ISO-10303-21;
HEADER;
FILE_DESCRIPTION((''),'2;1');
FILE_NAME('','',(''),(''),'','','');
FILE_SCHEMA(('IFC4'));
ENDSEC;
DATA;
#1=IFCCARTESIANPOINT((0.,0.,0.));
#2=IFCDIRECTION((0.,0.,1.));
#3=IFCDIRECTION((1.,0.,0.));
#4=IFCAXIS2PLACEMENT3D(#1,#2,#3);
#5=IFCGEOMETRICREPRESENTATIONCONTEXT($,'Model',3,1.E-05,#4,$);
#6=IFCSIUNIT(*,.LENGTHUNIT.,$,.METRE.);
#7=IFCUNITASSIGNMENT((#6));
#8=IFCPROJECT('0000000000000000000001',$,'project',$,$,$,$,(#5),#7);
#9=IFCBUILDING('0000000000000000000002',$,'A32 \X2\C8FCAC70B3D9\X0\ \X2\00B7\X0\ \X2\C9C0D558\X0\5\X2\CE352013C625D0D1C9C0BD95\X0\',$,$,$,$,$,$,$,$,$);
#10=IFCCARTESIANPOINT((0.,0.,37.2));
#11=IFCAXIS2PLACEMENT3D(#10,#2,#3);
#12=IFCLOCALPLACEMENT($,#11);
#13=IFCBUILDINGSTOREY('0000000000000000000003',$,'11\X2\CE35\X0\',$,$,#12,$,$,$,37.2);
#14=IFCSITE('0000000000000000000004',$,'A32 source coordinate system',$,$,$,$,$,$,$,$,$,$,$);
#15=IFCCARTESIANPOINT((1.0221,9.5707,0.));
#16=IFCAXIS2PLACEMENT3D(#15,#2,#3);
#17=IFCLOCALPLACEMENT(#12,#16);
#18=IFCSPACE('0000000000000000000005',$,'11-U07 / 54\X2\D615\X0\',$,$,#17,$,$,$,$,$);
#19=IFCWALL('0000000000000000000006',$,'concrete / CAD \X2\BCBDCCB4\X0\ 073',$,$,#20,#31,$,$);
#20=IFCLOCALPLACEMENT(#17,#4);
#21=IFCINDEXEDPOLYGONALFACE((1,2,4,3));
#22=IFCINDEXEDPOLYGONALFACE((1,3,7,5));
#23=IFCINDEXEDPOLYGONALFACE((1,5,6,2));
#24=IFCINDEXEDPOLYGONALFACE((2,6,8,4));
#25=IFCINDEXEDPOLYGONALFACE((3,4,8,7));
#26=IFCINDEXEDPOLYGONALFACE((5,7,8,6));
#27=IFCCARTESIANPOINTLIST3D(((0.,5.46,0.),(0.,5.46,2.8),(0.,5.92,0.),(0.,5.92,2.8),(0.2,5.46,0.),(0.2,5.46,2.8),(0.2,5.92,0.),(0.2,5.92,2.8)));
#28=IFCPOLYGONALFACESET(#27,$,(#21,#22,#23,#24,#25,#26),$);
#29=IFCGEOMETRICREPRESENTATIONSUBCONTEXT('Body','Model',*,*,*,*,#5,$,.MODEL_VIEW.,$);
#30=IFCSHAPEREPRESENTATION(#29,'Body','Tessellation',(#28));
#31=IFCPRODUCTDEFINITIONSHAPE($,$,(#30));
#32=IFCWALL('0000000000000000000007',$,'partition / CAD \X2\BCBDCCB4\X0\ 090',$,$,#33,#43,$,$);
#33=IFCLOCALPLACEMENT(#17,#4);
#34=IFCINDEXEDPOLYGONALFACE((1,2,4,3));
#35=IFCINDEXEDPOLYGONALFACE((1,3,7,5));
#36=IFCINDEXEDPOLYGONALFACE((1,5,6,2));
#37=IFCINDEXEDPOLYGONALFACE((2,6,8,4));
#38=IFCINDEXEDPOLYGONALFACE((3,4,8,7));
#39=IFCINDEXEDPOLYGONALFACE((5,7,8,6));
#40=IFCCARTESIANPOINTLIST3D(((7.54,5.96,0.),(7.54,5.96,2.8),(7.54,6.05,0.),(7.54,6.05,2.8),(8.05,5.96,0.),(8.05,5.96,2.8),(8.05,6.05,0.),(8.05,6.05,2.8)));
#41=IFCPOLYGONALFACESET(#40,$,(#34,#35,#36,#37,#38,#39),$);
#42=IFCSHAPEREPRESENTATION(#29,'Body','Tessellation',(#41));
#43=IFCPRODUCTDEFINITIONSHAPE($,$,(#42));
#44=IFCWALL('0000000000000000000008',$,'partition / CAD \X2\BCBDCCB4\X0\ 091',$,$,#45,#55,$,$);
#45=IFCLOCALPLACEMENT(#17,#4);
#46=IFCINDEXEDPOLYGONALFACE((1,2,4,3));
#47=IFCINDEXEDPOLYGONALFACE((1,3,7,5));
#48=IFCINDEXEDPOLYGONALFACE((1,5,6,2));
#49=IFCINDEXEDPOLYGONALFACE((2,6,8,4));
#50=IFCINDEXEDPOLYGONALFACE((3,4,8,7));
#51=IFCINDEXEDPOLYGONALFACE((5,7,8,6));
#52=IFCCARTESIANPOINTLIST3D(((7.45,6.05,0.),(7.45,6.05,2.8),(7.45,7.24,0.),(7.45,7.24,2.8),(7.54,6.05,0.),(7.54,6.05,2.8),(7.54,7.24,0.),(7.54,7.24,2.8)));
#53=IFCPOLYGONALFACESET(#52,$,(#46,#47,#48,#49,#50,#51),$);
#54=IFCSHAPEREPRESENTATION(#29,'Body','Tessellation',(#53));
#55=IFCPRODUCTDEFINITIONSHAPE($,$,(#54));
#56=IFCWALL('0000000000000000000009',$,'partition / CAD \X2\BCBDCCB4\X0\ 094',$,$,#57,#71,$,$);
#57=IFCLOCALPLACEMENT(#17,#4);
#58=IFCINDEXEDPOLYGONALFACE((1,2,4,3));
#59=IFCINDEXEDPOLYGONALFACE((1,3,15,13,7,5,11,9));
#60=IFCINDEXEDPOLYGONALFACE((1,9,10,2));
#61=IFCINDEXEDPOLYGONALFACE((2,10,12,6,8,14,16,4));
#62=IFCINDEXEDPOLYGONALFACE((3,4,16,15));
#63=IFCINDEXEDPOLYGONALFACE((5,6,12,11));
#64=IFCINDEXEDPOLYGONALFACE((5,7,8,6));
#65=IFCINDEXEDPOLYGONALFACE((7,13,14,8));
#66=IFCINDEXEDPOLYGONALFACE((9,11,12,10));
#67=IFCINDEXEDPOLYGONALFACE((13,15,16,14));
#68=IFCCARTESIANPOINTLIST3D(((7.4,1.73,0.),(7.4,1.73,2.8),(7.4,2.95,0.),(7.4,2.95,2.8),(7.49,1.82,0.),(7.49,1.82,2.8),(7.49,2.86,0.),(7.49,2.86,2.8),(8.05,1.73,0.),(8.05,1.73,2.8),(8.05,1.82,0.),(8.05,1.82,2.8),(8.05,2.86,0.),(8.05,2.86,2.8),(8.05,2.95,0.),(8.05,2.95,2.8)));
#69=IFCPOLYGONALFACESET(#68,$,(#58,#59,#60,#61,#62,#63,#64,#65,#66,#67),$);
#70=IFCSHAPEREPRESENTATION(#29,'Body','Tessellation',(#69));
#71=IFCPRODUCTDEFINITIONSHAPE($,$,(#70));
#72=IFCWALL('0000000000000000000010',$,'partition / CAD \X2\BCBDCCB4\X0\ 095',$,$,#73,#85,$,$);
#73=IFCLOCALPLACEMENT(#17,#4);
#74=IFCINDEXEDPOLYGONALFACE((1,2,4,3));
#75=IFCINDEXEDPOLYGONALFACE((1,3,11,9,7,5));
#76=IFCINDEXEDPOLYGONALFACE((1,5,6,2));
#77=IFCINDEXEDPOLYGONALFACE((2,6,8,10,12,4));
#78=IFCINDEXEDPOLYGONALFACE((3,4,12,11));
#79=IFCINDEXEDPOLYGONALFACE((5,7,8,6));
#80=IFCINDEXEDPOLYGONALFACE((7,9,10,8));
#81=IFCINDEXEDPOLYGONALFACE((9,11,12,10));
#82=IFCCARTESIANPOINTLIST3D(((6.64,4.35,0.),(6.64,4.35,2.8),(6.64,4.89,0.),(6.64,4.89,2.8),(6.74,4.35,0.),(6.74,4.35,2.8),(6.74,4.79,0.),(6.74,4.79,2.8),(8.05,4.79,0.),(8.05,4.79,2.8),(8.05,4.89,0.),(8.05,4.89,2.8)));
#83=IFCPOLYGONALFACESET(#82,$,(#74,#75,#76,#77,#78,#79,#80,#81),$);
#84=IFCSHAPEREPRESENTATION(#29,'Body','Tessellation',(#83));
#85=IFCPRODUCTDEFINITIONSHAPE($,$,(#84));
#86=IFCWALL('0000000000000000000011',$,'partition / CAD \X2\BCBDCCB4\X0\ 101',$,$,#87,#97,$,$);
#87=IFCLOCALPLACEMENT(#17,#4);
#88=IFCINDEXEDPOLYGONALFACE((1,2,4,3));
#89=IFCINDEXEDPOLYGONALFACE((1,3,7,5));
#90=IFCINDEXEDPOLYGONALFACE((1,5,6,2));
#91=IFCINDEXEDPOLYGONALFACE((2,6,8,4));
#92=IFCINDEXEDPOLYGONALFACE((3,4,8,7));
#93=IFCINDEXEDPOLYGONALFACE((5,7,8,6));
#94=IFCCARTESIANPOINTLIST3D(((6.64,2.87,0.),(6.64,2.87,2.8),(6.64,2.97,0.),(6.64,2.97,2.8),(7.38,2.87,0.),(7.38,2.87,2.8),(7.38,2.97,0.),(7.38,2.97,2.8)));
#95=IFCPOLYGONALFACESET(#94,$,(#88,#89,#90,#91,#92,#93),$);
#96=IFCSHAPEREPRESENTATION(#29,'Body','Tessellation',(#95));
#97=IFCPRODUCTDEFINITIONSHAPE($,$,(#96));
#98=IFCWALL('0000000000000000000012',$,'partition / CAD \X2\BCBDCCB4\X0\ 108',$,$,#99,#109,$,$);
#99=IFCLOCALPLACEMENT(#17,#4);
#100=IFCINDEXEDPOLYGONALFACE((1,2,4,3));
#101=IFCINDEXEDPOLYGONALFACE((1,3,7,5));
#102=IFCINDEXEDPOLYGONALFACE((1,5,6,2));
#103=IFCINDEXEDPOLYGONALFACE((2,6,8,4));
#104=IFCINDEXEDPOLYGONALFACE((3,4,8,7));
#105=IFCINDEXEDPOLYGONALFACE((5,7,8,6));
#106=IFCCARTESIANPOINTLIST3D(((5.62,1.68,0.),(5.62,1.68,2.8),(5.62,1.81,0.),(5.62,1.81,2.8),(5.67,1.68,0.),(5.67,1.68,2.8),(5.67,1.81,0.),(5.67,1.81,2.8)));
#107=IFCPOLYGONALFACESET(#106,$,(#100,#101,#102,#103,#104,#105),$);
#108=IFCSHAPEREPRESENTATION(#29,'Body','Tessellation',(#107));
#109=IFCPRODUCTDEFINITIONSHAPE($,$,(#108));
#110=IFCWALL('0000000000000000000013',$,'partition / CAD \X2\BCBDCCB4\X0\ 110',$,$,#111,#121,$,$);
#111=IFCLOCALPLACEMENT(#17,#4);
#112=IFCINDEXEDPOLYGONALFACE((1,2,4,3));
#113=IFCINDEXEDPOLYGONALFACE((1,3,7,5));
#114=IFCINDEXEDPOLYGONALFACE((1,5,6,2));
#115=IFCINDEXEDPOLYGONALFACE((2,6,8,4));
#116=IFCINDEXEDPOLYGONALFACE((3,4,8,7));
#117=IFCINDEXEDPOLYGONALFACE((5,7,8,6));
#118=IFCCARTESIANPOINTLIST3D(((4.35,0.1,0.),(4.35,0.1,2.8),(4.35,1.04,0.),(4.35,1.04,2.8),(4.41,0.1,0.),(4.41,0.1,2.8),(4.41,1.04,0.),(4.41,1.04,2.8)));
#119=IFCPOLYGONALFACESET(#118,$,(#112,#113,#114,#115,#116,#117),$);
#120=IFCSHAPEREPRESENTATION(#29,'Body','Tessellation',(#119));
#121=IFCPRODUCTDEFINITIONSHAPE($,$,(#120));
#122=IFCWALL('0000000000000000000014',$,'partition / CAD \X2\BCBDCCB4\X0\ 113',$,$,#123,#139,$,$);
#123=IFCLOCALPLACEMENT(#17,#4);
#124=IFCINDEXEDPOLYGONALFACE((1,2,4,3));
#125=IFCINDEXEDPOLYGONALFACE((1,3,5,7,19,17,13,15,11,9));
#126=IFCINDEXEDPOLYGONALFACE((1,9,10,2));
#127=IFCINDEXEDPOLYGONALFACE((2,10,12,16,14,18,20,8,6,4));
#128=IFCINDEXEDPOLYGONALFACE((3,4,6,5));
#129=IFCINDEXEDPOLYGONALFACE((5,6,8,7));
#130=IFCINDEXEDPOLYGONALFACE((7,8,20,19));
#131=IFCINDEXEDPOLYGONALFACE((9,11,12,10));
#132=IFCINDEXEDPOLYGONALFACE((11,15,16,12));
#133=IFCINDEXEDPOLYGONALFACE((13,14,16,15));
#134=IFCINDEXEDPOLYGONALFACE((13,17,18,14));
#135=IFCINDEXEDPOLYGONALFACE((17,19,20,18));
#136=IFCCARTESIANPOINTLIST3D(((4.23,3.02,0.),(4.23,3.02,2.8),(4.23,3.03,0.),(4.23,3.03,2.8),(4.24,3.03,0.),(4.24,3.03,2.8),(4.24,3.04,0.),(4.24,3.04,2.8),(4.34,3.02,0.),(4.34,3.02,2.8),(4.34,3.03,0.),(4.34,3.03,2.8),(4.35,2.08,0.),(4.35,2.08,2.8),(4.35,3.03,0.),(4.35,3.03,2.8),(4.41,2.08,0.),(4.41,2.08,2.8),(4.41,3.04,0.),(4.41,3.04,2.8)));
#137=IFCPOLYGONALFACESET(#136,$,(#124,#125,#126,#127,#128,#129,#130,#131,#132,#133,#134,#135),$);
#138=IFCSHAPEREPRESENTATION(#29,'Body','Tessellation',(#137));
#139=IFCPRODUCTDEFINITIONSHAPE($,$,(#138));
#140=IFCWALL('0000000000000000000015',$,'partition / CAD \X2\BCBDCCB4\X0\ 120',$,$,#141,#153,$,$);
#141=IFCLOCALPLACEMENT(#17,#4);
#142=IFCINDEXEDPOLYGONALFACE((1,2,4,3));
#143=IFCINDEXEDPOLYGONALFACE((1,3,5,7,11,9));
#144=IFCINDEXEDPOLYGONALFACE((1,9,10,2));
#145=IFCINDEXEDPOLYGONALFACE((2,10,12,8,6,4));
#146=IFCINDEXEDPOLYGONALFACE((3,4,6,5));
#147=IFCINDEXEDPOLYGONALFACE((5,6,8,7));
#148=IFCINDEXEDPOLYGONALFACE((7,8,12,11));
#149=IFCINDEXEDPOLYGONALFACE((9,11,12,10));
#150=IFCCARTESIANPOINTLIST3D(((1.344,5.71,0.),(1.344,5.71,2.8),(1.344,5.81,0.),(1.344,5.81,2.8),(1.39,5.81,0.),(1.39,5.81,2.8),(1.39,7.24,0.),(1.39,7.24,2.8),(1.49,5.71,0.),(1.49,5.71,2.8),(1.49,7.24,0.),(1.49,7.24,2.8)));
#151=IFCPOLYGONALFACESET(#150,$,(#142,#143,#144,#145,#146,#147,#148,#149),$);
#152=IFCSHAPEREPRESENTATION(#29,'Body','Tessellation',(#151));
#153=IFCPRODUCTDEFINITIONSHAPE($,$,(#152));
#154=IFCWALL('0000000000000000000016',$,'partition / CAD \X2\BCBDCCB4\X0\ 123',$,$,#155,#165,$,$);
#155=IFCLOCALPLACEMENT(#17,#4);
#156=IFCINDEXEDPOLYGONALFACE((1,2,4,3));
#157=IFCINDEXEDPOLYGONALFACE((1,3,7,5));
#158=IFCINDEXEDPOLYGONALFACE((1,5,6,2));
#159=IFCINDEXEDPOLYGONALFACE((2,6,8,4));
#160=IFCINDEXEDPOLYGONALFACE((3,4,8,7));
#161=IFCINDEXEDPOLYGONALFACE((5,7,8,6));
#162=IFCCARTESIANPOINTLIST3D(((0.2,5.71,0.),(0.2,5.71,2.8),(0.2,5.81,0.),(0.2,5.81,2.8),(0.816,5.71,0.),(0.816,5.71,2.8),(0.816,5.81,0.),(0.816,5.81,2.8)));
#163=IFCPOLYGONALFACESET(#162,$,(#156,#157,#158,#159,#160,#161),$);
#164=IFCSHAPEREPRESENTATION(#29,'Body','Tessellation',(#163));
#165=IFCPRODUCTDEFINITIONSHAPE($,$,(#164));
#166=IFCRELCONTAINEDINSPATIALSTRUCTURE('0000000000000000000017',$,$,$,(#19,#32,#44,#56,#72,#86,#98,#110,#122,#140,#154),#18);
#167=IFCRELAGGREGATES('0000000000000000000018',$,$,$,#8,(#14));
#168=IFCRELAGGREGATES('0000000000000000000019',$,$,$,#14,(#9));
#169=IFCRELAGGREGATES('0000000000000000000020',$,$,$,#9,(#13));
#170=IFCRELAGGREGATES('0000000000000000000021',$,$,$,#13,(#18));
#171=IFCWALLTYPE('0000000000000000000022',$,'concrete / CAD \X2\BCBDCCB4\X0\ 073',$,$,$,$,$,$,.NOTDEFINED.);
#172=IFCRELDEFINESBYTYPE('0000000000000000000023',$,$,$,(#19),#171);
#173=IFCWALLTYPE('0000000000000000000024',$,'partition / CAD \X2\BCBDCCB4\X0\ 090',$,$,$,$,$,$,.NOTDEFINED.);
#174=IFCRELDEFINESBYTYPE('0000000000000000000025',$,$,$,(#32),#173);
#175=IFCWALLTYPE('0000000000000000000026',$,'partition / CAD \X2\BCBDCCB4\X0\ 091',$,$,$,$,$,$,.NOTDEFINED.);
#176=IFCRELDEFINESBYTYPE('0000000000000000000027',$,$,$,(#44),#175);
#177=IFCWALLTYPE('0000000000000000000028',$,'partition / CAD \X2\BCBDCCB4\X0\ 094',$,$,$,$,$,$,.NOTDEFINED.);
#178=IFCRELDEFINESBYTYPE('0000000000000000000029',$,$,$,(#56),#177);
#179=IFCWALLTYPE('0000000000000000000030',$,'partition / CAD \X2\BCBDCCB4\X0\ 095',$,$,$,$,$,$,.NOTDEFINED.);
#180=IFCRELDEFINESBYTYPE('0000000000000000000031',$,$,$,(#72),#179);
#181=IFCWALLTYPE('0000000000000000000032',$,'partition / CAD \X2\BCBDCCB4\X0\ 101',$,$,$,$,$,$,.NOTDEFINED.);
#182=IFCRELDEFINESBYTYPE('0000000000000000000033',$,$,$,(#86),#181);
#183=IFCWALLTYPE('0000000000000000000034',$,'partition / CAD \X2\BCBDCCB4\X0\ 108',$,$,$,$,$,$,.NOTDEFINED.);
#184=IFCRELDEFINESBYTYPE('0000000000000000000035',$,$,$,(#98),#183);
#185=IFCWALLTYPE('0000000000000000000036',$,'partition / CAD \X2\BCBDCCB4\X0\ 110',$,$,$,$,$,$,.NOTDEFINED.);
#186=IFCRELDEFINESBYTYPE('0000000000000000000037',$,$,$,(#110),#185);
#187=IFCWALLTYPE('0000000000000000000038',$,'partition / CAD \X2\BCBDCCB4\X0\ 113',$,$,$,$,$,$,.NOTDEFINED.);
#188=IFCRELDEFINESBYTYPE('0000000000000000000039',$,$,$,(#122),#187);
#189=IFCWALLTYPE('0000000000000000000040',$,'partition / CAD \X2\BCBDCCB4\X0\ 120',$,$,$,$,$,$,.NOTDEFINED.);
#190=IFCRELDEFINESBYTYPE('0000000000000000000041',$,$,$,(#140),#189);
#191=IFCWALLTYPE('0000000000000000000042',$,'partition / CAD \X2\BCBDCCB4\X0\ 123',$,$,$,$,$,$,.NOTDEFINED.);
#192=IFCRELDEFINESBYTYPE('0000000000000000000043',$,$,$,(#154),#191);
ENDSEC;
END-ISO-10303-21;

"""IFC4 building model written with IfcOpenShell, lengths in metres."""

from ifc_helpers import new_model, si_unit, frame, origin, origin_with_axes, place, context, subcontext, project, spatial, polyline, outline, extrude, source, transform, mapped, type_object, type_shapes, element, save


model = new_model("IFC4")

# Units and contexts
model_context = context("Model", 3, precision=1e-05, world=origin_with_axes())
body_context = subcontext(model_context, "Body", "Model", "MODEL_VIEW")
ifc_project = project(units=[si_unit("LENGTHUNIT", "METRE")], contexts=[model_context])

# Site, building, storey, space
site = spatial("IfcSite", under=ifc_project, Name="A32 source coordinate system")
building = spatial("IfcBuilding", under=site, Name="A32 주거동 · 지하5층–옥탑지붕")
storey_placement = place(None, frame((0.0, 0.0, 37.2), z_axis=(0.0, 0.0, 1.0), x_axis=(1.0, 0.0, 0.0)))
storey = spatial("IfcBuildingStorey", under=building, at=storey_placement, Name="11층", Elevation=37.2)
space_1_placement = place(storey_placement, frame((1.0221, 9.5707, 0.0), z_axis=(0.0, 0.0, 1.0), x_axis=(1.0, 0.0, 0.0)))
space_1 = spatial("IfcSpace", under=storey, at=space_1_placement, Name="11-U07 / 54형")

# Walls
wall_type_1 = type_object("IfcWallType", Name="concrete / CAD 벽체 073", PredefinedType="NOTDEFINED")
shared_shape_1 = source(origin(), body_context, "Body", "SweptSolid", [
    extrude(outline(polyline([(0.2, 5.92), (0.2, 5.46), (0.0, 5.46), (0.0, 5.92), (0.2, 5.92)])), origin(), (0.0, 0.0, 1.0), 2.8),
])
type_shapes(wall_type_1, [shared_shape_1])
wall_1_placement = place(space_1_placement, origin_with_axes())
element("IfcWall", 1, at=wall_1_placement, inside=space_1, type_object=wall_type_1, Name="concrete / CAD 벽체 073", context=body_context, shape_type="MappedRepresentation", body=[
    mapped(shared_shape_1, transform((0.0, 0.0, 0.0), scale=1.0)),
])
wall_type_2 = type_object("IfcWallType", Name="partition / CAD 벽체 090", PredefinedType="NOTDEFINED")
shared_shape_2 = source(origin(), body_context, "Body", "SweptSolid", [
    extrude(outline(polyline([(7.54, 5.96), (7.54, 6.05), (8.05, 6.05), (8.05, 5.96), (7.54, 5.96)])), origin(), (0.0, 0.0, 1.0), 2.8),
])
type_shapes(wall_type_2, [shared_shape_2])
wall_2_placement = place(space_1_placement, origin_with_axes())
element("IfcWall", 2, at=wall_2_placement, inside=space_1, type_object=wall_type_2, Name="partition / CAD 벽체 090", context=body_context, shape_type="MappedRepresentation", body=[
    mapped(shared_shape_2, transform((0.0, 0.0, 0.0), scale=1.0)),
])
wall_type_3 = type_object("IfcWallType", Name="partition / CAD 벽체 091", PredefinedType="NOTDEFINED")
shared_shape_3 = source(origin(), body_context, "Body", "SweptSolid", [
    extrude(outline(polyline([(7.54, 6.05), (7.45, 6.05), (7.45, 7.24), (7.54, 7.24), (7.54, 6.05)])), origin(), (0.0, 0.0, 1.0), 2.8),
])
type_shapes(wall_type_3, [shared_shape_3])
wall_3_placement = place(space_1_placement, origin_with_axes())
element("IfcWall", 3, at=wall_3_placement, inside=space_1, type_object=wall_type_3, Name="partition / CAD 벽체 091", context=body_context, shape_type="MappedRepresentation", body=[
    mapped(shared_shape_3, transform((0.0, 0.0, 0.0), scale=1.0)),
])
wall_type_4 = type_object("IfcWallType", Name="partition / CAD 벽체 094", PredefinedType="NOTDEFINED")
shared_shape_4 = source(origin(), body_context, "Body", "SweptSolid", [
    extrude(outline(polyline([(8.05, 1.73), (7.4, 1.73), (7.4, 2.95), (8.05, 2.95), (8.05, 2.86), (7.49, 2.86), (7.49, 1.82), (8.05, 1.82), (8.05, 1.73)])), origin(), (0.0, 0.0, 1.0), 2.8),
])
type_shapes(wall_type_4, [shared_shape_4])
wall_4_placement = place(space_1_placement, origin_with_axes())
element("IfcWall", 4, at=wall_4_placement, inside=space_1, type_object=wall_type_4, Name="partition / CAD 벽체 094", context=body_context, shape_type="MappedRepresentation", body=[
    mapped(shared_shape_4, transform((0.0, 0.0, 0.0), scale=1.0)),
])
wall_type_5 = type_object("IfcWallType", Name="partition / CAD 벽체 095", PredefinedType="NOTDEFINED")
shared_shape_5 = source(origin(), body_context, "Body", "SweptSolid", [
    extrude(outline(polyline([(6.64, 4.89), (8.05, 4.89), (8.05, 4.79), (6.74, 4.79), (6.74, 4.35), (6.64, 4.35), (6.64, 4.89)])), origin(), (0.0, 0.0, 1.0), 2.8),
])
type_shapes(wall_type_5, [shared_shape_5])
wall_5_placement = place(space_1_placement, origin_with_axes())
element("IfcWall", 5, at=wall_5_placement, inside=space_1, type_object=wall_type_5, Name="partition / CAD 벽체 095", context=body_context, shape_type="MappedRepresentation", body=[
    mapped(shared_shape_5, transform((0.0, 0.0, 0.0), scale=1.0)),
])
wall_type_6 = type_object("IfcWallType", Name="partition / CAD 벽체 101", PredefinedType="NOTDEFINED")
shared_shape_6 = source(origin(), body_context, "Body", "SweptSolid", [
    extrude(outline(polyline([(7.38, 2.97), (7.38, 2.87), (6.64, 2.87), (6.64, 2.97), (7.38, 2.97)])), origin(), (0.0, 0.0, 1.0), 2.8),
])
type_shapes(wall_type_6, [shared_shape_6])
wall_6_placement = place(space_1_placement, origin_with_axes())
element("IfcWall", 6, at=wall_6_placement, inside=space_1, type_object=wall_type_6, Name="partition / CAD 벽체 101", context=body_context, shape_type="MappedRepresentation", body=[
    mapped(shared_shape_6, transform((0.0, 0.0, 0.0), scale=1.0)),
])
wall_type_7 = type_object("IfcWallType", Name="partition / CAD 벽체 108", PredefinedType="NOTDEFINED")
shared_shape_7 = source(origin(), body_context, "Body", "SweptSolid", [
    extrude(outline(polyline([(5.67, 1.68), (5.62, 1.68), (5.62, 1.81), (5.67, 1.81), (5.67, 1.68)])), origin(), (0.0, 0.0, 1.0), 2.8),
])
type_shapes(wall_type_7, [shared_shape_7])
wall_7_placement = place(space_1_placement, origin_with_axes())
element("IfcWall", 7, at=wall_7_placement, inside=space_1, type_object=wall_type_7, Name="partition / CAD 벽체 108", context=body_context, shape_type="MappedRepresentation", body=[
    mapped(shared_shape_7, transform((0.0, 0.0, 0.0), scale=1.0)),
])
wall_type_8 = type_object("IfcWallType", Name="partition / CAD 벽체 110", PredefinedType="NOTDEFINED")
shared_shape_8 = source(origin(), body_context, "Body", "SweptSolid", [
    extrude(outline(polyline([(4.35, 1.04), (4.41, 1.04), (4.41, 0.1), (4.35, 0.1), (4.35, 1.04)])), origin(), (0.0, 0.0, 1.0), 2.8),
])
type_shapes(wall_type_8, [shared_shape_8])
wall_8_placement = place(space_1_placement, origin_with_axes())
element("IfcWall", 8, at=wall_8_placement, inside=space_1, type_object=wall_type_8, Name="partition / CAD 벽체 110", context=body_context, shape_type="MappedRepresentation", body=[
    mapped(shared_shape_8, transform((0.0, 0.0, 0.0), scale=1.0)),
])
wall_type_9 = type_object("IfcWallType", Name="partition / CAD 벽체 113", PredefinedType="NOTDEFINED")
shared_shape_9 = source(origin(), body_context, "Body", "SweptSolid", [
    extrude(outline(polyline([(4.24, 3.04), (4.41, 3.04), (4.41, 2.08), (4.35, 2.08), (4.35, 3.03), (4.34, 3.03), (4.34, 3.02), (4.23, 3.02), (4.23, 3.03), (4.24, 3.03), (4.24, 3.04)])), origin(), (0.0, 0.0, 1.0), 2.8),
])
type_shapes(wall_type_9, [shared_shape_9])
wall_9_placement = place(space_1_placement, origin_with_axes())
element("IfcWall", 9, at=wall_9_placement, inside=space_1, type_object=wall_type_9, Name="partition / CAD 벽체 113", context=body_context, shape_type="MappedRepresentation", body=[
    mapped(shared_shape_9, transform((0.0, 0.0, 0.0), scale=1.0)),
])
wall_type_10 = type_object("IfcWallType", Name="partition / CAD 벽체 120", PredefinedType="NOTDEFINED")
shared_shape_10 = source(origin(), body_context, "Body", "SweptSolid", [
    extrude(outline(polyline([(1.39, 7.24), (1.49, 7.24), (1.49, 5.71), (1.344, 5.71), (1.344, 5.81), (1.39, 5.81), (1.39, 7.24)])), origin(), (0.0, 0.0, 1.0), 2.8),
])
type_shapes(wall_type_10, [shared_shape_10])
wall_10_placement = place(space_1_placement, origin_with_axes())
element("IfcWall", 10, at=wall_10_placement, inside=space_1, type_object=wall_type_10, Name="partition / CAD 벽체 120", context=body_context, shape_type="MappedRepresentation", body=[
    mapped(shared_shape_10, transform((0.0, 0.0, 0.0), scale=1.0)),
])
wall_type_11 = type_object("IfcWallType", Name="partition / CAD 벽체 123", PredefinedType="NOTDEFINED")
shared_shape_11 = source(origin(), body_context, "Body", "SweptSolid", [
    extrude(outline(polyline([(0.816, 5.81), (0.816, 5.71), (0.2, 5.71), (0.2, 5.81), (0.816, 5.81)])), origin(), (0.0, 0.0, 1.0), 2.8),
])
type_shapes(wall_type_11, [shared_shape_11])
wall_11_placement = place(space_1_placement, origin_with_axes())
element("IfcWall", 11, at=wall_11_placement, inside=space_1, type_object=wall_type_11, Name="partition / CAD 벽체 123", context=body_context, shape_type="MappedRepresentation", body=[
    mapped(shared_shape_11, transform((0.0, 0.0, 0.0), scale=1.0)),
])

save(model, "model.ifc")
